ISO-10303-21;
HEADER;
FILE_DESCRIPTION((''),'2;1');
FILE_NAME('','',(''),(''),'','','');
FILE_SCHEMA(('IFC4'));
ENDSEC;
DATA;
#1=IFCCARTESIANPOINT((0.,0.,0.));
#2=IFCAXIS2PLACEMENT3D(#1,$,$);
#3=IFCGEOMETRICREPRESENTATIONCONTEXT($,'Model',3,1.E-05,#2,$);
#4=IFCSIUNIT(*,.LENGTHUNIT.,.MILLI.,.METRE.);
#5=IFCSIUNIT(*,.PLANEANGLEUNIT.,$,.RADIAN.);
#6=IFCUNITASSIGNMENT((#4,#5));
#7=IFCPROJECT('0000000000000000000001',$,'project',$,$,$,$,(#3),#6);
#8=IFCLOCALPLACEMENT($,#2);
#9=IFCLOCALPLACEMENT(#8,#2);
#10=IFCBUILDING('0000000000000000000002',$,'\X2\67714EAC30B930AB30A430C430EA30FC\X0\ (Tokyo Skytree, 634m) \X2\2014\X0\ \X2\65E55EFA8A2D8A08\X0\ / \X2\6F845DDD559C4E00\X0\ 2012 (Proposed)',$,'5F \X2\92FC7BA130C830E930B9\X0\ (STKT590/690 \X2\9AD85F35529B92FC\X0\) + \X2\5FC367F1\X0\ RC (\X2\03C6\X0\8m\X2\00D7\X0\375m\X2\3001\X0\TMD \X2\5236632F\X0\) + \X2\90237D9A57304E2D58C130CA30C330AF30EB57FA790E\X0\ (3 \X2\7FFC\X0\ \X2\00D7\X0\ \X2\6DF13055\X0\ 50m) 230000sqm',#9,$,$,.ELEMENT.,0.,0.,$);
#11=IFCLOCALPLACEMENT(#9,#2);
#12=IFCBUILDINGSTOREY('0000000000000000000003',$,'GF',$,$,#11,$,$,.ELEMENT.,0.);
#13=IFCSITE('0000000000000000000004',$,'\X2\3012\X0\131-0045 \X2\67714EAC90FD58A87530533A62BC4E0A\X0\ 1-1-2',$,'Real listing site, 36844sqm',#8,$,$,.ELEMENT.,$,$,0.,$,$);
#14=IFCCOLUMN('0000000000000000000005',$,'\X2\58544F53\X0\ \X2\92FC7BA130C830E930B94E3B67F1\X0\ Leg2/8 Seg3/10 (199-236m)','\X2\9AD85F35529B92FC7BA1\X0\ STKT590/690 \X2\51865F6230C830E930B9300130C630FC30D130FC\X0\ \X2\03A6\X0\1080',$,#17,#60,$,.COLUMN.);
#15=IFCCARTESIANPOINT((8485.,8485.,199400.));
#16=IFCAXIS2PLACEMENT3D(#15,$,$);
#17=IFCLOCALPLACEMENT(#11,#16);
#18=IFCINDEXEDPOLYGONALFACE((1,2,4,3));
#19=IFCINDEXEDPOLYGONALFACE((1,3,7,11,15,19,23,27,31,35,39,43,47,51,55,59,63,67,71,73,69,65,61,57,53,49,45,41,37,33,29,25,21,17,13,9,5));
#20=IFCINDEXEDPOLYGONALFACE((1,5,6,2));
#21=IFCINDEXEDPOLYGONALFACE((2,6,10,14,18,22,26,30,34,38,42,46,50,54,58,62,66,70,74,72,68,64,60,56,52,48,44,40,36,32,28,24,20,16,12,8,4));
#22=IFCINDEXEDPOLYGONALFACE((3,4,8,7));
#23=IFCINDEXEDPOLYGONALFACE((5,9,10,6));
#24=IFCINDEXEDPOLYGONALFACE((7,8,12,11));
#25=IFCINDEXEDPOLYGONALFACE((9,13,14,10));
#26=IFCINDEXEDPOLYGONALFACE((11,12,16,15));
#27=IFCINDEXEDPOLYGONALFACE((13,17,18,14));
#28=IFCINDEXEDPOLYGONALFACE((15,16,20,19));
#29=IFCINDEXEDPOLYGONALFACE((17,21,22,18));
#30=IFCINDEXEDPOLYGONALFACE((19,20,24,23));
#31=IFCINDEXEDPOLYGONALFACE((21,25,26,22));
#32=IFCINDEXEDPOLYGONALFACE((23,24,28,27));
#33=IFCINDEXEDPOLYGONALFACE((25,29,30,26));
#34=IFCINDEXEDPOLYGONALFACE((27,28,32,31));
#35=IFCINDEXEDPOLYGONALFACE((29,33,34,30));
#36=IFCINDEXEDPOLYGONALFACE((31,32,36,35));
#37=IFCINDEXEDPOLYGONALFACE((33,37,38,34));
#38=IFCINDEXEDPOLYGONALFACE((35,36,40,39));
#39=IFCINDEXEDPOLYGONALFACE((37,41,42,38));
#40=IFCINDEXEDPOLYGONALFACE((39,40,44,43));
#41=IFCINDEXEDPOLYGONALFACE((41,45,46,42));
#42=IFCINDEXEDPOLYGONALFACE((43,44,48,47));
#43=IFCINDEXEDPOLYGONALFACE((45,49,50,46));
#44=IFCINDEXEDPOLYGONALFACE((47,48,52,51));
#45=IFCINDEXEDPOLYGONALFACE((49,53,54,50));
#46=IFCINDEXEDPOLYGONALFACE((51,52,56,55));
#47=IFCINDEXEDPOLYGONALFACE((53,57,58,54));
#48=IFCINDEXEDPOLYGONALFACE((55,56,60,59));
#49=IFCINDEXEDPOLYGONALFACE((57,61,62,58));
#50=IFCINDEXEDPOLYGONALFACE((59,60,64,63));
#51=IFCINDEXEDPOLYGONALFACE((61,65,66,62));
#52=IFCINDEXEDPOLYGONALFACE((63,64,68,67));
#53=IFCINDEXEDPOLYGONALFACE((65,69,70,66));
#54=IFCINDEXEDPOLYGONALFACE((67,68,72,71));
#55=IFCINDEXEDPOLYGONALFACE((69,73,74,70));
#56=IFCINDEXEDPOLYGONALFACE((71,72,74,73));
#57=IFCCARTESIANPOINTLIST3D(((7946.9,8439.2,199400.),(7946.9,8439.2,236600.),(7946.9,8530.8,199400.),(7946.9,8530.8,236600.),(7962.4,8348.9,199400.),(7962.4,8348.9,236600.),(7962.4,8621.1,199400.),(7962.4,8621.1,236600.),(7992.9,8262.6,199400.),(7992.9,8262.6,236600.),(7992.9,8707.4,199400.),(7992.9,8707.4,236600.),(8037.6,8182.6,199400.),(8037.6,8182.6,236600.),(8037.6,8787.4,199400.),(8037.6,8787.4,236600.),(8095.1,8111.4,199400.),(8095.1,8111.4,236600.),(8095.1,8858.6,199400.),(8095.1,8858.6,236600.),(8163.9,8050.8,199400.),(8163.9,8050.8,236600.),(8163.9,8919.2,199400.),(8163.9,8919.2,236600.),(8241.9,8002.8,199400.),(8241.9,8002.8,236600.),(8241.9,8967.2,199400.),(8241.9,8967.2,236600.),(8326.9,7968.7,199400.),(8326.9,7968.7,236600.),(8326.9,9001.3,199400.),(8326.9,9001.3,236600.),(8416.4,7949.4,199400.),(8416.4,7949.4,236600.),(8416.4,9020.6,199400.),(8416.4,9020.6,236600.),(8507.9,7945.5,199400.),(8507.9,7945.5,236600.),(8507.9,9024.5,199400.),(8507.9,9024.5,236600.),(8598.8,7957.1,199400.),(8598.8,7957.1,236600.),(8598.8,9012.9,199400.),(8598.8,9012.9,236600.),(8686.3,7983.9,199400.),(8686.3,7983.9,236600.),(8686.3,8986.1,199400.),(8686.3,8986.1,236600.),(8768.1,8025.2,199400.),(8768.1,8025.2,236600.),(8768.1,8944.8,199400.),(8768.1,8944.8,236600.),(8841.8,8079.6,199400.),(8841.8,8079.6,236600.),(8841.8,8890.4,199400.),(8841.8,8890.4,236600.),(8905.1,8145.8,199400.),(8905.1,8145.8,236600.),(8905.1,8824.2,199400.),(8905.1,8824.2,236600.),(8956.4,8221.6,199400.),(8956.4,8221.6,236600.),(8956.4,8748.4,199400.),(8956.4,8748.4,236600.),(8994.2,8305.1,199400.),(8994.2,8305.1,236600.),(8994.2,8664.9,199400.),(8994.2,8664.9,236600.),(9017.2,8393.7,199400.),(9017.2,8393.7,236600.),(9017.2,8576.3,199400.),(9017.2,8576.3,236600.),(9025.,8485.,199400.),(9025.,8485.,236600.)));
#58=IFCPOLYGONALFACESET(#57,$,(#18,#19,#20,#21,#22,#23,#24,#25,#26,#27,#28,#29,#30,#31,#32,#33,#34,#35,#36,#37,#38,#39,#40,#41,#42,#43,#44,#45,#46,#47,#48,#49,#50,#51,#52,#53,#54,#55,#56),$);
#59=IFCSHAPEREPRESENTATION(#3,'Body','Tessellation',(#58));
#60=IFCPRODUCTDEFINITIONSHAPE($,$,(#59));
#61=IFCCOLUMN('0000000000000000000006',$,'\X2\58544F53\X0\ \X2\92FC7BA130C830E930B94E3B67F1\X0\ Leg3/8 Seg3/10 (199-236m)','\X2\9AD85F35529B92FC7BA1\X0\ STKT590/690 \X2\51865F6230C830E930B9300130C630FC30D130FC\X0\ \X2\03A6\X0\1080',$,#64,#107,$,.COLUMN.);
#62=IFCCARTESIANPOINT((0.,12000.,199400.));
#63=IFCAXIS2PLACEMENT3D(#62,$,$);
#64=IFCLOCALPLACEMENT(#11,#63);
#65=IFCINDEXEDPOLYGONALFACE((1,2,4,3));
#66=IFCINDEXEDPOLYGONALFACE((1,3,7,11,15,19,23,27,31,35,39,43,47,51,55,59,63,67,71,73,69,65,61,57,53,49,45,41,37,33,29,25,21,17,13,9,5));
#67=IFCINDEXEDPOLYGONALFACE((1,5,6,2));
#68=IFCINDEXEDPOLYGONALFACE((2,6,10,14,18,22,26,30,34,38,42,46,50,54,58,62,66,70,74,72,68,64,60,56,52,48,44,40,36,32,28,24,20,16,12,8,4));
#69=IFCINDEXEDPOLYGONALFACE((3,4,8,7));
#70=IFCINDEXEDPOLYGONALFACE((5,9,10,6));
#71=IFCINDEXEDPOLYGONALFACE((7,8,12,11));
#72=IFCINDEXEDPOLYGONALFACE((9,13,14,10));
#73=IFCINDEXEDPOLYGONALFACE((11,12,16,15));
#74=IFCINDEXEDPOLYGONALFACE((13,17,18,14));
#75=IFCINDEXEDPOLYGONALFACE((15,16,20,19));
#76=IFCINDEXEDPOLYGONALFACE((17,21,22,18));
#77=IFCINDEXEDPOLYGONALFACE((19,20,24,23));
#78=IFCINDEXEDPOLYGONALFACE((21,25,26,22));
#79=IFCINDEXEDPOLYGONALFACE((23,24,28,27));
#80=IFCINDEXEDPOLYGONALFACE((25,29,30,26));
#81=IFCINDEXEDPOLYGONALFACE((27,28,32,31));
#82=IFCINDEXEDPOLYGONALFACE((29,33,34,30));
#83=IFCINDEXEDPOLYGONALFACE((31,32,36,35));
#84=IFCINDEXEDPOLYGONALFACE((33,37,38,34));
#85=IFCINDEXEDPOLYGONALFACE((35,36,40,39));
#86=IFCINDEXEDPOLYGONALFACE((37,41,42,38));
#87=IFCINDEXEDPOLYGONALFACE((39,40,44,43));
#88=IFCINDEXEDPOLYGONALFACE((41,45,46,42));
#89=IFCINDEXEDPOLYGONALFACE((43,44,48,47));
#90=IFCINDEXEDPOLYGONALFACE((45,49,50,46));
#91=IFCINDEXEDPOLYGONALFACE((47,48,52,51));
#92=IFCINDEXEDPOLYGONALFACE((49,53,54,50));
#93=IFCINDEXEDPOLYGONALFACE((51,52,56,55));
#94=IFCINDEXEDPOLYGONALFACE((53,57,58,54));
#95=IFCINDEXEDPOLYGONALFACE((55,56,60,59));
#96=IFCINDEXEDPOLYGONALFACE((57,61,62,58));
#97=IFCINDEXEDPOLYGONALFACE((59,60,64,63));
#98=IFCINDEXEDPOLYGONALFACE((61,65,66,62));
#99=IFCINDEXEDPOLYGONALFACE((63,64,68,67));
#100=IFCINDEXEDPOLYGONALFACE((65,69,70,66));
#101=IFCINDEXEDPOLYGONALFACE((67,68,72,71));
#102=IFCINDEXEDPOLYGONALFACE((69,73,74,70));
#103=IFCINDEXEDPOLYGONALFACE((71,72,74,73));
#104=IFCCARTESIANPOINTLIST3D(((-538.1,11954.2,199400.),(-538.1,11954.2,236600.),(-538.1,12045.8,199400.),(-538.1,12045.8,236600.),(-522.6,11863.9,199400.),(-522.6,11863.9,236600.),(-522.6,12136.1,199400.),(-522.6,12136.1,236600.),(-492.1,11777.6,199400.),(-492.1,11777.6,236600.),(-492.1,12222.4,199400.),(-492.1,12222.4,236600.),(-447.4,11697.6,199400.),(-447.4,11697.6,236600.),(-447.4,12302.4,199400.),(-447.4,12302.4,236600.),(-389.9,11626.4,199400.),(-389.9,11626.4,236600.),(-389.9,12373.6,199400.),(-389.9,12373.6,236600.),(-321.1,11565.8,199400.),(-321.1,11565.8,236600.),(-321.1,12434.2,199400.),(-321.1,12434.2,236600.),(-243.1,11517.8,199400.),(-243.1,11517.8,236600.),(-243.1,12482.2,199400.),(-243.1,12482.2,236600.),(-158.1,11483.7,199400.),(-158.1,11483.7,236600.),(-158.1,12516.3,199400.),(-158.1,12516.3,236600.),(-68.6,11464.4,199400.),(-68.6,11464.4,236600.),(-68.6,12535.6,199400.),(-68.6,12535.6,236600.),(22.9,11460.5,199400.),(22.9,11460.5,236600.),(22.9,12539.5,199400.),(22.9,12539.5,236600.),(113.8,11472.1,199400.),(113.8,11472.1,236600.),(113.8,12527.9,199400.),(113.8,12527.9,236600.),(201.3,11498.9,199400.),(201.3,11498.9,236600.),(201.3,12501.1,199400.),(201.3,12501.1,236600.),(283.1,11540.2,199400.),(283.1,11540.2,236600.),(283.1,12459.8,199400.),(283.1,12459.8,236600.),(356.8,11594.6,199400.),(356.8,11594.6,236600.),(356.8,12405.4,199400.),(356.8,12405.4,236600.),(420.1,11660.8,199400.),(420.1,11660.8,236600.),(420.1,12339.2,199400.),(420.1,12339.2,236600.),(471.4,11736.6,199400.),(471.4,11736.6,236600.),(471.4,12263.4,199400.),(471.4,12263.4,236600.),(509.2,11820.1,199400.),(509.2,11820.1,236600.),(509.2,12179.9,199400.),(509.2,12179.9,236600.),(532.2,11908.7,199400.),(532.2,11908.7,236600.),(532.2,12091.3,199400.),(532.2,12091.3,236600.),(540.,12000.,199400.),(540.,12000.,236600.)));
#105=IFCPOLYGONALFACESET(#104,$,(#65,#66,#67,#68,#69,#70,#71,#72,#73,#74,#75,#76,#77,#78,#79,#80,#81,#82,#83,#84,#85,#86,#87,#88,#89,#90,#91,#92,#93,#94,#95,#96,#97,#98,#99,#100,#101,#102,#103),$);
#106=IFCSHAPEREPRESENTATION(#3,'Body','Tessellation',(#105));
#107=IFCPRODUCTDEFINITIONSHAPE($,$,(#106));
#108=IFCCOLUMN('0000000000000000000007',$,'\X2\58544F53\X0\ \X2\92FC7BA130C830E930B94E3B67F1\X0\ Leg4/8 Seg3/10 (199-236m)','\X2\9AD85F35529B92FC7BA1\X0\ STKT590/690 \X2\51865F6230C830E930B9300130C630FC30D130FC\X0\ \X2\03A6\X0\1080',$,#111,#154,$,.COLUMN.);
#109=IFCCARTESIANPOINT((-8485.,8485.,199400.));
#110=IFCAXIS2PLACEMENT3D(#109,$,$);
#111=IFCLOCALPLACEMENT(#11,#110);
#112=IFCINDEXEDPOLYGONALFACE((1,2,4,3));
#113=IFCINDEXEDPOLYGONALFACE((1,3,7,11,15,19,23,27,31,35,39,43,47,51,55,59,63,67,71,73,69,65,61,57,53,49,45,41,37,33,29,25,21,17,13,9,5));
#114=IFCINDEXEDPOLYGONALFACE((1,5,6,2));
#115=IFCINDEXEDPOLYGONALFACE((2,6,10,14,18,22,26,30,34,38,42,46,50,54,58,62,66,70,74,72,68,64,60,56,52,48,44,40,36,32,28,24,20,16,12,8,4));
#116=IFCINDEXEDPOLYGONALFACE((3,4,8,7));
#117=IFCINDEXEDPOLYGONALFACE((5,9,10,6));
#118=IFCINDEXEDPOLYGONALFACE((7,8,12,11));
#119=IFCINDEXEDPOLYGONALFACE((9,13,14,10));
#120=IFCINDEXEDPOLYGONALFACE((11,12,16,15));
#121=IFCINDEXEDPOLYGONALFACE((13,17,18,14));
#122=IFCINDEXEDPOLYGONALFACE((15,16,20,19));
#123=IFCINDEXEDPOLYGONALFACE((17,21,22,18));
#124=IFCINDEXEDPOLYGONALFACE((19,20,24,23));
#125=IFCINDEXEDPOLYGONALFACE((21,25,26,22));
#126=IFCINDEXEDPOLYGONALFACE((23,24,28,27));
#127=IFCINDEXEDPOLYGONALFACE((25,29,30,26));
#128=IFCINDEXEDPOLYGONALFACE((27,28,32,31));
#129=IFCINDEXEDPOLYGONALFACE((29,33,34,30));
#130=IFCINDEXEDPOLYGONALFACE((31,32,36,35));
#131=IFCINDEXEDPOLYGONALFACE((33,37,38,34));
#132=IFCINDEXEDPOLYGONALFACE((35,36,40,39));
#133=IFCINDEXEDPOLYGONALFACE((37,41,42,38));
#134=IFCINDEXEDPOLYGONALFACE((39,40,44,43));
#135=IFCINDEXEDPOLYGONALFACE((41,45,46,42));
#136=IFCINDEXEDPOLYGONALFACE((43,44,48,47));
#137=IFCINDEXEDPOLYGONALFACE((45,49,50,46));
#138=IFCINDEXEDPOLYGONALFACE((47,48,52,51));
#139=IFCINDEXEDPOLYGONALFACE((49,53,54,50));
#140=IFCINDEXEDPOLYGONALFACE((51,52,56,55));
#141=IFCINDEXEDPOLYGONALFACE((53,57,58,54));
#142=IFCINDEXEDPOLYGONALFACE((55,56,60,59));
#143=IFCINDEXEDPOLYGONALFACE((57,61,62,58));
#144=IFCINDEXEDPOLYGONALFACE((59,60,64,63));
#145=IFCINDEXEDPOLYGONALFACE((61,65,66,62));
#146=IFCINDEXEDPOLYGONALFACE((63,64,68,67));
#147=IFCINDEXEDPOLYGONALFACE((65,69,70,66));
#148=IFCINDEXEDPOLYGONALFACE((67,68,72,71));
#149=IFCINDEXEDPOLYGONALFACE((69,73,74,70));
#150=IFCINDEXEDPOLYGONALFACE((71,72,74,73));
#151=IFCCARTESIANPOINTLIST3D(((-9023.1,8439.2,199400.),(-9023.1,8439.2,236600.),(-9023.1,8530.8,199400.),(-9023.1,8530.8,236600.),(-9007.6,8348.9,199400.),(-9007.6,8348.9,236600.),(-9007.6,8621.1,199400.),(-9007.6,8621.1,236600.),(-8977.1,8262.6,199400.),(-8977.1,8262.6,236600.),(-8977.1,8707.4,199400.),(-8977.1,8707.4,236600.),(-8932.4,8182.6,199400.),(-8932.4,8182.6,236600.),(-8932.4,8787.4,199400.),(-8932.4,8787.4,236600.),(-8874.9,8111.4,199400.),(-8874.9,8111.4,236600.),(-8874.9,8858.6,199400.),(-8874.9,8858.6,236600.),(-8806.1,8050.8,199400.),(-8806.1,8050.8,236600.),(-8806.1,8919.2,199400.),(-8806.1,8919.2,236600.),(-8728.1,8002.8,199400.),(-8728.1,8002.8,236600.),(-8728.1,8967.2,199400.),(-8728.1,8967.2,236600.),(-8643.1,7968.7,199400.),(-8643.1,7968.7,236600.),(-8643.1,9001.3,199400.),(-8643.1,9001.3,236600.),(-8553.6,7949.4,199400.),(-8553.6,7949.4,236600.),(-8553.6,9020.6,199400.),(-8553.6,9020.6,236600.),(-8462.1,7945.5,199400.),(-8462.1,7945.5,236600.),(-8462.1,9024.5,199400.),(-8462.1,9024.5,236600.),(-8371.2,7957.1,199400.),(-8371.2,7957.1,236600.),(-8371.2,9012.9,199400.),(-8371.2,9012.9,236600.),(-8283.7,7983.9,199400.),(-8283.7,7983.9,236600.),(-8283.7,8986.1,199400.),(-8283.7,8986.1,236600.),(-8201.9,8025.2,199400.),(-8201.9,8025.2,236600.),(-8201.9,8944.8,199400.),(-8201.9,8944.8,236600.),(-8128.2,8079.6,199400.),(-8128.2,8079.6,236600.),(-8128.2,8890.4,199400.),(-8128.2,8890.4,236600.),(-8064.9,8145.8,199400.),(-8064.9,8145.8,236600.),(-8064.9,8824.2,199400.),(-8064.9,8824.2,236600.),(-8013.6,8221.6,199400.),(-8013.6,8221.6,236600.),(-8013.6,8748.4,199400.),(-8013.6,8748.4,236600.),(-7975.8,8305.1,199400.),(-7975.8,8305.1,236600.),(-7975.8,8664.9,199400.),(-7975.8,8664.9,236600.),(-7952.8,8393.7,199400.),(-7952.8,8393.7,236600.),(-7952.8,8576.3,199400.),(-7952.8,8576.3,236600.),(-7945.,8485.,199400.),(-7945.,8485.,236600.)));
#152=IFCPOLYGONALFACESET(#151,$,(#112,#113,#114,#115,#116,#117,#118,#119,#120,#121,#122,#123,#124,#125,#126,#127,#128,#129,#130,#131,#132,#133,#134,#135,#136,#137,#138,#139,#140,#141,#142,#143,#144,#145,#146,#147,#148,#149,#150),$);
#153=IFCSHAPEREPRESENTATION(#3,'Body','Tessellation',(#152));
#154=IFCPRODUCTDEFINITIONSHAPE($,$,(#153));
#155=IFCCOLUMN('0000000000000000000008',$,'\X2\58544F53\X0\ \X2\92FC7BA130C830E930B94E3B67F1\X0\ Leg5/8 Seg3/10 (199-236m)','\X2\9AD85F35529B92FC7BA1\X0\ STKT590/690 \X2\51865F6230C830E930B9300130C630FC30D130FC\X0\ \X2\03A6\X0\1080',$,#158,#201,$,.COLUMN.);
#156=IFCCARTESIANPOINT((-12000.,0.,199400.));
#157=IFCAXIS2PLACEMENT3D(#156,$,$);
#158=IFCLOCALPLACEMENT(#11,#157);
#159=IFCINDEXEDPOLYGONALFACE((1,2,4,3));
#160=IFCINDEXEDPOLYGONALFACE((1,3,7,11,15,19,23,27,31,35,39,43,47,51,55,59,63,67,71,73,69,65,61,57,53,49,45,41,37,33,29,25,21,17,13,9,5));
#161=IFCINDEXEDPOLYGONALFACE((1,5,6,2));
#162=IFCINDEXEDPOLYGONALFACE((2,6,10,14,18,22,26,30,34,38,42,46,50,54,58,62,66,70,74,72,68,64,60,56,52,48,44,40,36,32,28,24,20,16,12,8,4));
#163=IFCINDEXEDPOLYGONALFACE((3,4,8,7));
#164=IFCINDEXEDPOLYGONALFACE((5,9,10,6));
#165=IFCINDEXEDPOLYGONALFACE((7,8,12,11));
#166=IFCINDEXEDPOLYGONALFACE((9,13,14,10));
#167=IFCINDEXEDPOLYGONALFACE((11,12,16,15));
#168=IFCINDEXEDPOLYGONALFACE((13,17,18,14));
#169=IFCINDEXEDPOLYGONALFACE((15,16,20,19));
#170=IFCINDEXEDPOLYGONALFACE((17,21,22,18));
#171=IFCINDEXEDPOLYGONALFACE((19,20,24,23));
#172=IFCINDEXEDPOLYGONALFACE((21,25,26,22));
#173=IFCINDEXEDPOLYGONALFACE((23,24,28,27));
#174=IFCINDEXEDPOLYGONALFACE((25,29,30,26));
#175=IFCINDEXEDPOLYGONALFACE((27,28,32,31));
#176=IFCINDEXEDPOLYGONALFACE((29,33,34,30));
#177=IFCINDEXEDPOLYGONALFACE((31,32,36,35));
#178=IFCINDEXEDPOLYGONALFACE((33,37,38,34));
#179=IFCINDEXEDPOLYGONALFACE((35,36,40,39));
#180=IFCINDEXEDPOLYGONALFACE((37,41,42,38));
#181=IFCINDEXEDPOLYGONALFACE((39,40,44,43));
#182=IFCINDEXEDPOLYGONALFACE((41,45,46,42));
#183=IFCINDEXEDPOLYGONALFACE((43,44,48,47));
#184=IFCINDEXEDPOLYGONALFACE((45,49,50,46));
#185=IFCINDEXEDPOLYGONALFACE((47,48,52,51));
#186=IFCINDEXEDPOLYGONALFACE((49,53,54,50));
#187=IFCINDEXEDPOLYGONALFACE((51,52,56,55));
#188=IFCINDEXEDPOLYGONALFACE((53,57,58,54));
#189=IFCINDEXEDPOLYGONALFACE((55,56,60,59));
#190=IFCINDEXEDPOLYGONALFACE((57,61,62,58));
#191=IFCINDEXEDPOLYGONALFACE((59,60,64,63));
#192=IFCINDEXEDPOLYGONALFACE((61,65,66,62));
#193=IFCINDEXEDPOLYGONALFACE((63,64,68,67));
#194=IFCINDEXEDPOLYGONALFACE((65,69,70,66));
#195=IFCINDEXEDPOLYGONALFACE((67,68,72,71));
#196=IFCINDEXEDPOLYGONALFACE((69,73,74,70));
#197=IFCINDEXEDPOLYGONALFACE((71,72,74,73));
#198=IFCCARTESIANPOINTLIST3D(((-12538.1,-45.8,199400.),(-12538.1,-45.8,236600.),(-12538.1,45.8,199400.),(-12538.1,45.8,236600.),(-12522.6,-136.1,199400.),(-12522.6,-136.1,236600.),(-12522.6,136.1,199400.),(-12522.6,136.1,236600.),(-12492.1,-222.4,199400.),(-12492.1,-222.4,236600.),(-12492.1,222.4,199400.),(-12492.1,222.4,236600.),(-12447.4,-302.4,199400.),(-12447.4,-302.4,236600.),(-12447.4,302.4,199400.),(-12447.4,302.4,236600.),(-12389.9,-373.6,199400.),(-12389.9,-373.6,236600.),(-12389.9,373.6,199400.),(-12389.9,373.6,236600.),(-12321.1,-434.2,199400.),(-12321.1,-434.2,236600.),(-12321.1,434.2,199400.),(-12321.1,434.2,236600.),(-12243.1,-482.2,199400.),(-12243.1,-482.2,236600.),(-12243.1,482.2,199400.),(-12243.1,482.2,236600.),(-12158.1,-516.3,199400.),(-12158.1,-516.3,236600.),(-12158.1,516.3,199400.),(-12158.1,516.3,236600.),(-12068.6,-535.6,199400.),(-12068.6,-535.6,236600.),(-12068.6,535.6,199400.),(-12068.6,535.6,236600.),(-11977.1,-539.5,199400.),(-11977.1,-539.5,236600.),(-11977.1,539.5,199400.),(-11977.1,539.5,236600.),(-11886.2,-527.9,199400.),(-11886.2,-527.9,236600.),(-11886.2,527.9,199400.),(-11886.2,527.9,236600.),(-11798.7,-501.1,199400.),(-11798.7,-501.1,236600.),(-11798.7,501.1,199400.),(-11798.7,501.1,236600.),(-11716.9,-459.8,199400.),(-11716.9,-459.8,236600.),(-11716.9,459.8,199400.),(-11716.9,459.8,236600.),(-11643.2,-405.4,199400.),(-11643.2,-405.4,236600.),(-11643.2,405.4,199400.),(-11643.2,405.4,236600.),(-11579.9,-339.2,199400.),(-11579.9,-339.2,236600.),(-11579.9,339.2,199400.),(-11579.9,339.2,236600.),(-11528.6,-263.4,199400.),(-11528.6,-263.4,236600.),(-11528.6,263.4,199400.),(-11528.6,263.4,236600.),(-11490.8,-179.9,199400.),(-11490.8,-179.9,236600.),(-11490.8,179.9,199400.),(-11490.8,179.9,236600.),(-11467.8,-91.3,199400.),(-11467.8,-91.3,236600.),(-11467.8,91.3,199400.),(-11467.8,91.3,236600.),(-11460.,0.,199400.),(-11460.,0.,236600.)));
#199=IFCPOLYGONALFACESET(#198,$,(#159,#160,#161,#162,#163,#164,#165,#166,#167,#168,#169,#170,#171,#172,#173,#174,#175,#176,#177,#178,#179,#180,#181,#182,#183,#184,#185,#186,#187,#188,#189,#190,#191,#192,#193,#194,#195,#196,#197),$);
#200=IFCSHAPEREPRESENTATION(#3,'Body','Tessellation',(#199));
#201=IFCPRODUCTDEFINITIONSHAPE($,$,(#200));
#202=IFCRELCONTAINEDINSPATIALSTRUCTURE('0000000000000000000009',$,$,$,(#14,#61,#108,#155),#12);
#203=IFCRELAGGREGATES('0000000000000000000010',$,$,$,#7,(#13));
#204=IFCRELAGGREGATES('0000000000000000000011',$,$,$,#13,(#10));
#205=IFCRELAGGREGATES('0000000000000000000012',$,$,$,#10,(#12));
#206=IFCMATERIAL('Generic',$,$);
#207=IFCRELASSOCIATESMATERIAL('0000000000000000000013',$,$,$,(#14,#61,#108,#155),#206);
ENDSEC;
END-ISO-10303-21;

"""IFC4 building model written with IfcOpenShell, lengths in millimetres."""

from ifc_helpers import new_model, si_unit, frame, origin, origin_2d, place, context, project, spatial, circle, extrude, material, element, save


model = new_model("IFC4")

# Units and contexts
model_context = context("Model", 3, precision=1e-05, world=origin())
ifc_project = project(units=[si_unit("LENGTHUNIT", "METRE", prefix="MILLI"), si_unit("PLANEANGLEUNIT", "RADIAN")], contexts=[model_context])

# Site, building, storey
site_placement = place(None, origin())
site = spatial("IfcSite", under=ifc_project, at=site_placement, Name="〒131-0045 東京都墨田区押上 1-1-2", ObjectType="Real listing site, 36844sqm", CompositionType="ELEMENT", RefElevation=0.0)
building_placement = place(site_placement, origin())
building = spatial("IfcBuilding", under=site, at=building_placement, Name="東京スカイツリー (Tokyo Skytree, 634m) — 日建設計 / 澄川喜一 2012 (Proposed)", ObjectType="5F 鋼管トラス (STKT590/690 高張力鋼) + 心柱 RC (φ8m×375m、TMD 制振) + 連続地中壁ナックル基礎 (3 翼 × 深さ 50m) 230000sqm", CompositionType="ELEMENT", ElevationOfRefHeight=0.0, ElevationOfTerrain=0.0)
storey_placement = place(building_placement, origin())
storey = spatial("IfcBuildingStorey", under=building, at=storey_placement, Name="GF", CompositionType="ELEMENT", Elevation=0.0)

# Columns
ifc_material_1 = material(Name="Generic")
column_1_placement = place(storey_placement, frame((8485.0, 8485.0, 199400.0)))
element("IfcColumn", 1, at=column_1_placement, inside=storey, material=ifc_material_1, Name="塔体 鋼管トラス主柱 Leg2/8 Seg3/10 (199-236m)", Description="高張力鋼管 STKT590/690 円形トラス、テーパー Φ1080", PredefinedType="COLUMN", context=model_context, shape_type="SweptSolid", body=[
    extrude(circle(Radius=540.0, at=origin_2d()), frame((8485.0, 8485.0, 199400.0)), (0.0, 0.0, 1.0), 37200.0),
])
column_2_placement = place(storey_placement, frame((0.0, 12000.0, 199400.0)))
element("IfcColumn", 2, at=column_2_placement, inside=storey, material=ifc_material_1, Name="塔体 鋼管トラス主柱 Leg3/8 Seg3/10 (199-236m)", Description="高張力鋼管 STKT590/690 円形トラス、テーパー Φ1080", PredefinedType="COLUMN", context=model_context, shape_type="SweptSolid", body=[
    extrude(circle(Radius=540.0, at=origin_2d()), frame((0.0, 12000.0, 199400.0)), (0.0, 0.0, 1.0), 37200.0),
])
column_3_placement = place(storey_placement, frame((-8485.0, 8485.0, 199400.0)))
element("IfcColumn", 3, at=column_3_placement, inside=storey, material=ifc_material_1, Name="塔体 鋼管トラス主柱 Leg4/8 Seg3/10 (199-236m)", Description="高張力鋼管 STKT590/690 円形トラス、テーパー Φ1080", PredefinedType="COLUMN", context=model_context, shape_type="SweptSolid", body=[
    extrude(circle(Radius=540.0, at=origin_2d()), frame((-8485.0, 8485.0, 199400.0)), (0.0, 0.0, 1.0), 37200.0),
])
column_4_placement = place(storey_placement, frame((-12000.0, 0.0, 199400.0)))
element("IfcColumn", 4, at=column_4_placement, inside=storey, material=ifc_material_1, Name="塔体 鋼管トラス主柱 Leg5/8 Seg3/10 (199-236m)", Description="高張力鋼管 STKT590/690 円形トラス、テーパー Φ1080", PredefinedType="COLUMN", context=model_context, shape_type="SweptSolid", body=[
    extrude(circle(Radius=540.0, at=origin_2d()), frame((-12000.0, 0.0, 199400.0)), (0.0, 0.0, 1.0), 37200.0),
])

save(model, "model.ifc")
